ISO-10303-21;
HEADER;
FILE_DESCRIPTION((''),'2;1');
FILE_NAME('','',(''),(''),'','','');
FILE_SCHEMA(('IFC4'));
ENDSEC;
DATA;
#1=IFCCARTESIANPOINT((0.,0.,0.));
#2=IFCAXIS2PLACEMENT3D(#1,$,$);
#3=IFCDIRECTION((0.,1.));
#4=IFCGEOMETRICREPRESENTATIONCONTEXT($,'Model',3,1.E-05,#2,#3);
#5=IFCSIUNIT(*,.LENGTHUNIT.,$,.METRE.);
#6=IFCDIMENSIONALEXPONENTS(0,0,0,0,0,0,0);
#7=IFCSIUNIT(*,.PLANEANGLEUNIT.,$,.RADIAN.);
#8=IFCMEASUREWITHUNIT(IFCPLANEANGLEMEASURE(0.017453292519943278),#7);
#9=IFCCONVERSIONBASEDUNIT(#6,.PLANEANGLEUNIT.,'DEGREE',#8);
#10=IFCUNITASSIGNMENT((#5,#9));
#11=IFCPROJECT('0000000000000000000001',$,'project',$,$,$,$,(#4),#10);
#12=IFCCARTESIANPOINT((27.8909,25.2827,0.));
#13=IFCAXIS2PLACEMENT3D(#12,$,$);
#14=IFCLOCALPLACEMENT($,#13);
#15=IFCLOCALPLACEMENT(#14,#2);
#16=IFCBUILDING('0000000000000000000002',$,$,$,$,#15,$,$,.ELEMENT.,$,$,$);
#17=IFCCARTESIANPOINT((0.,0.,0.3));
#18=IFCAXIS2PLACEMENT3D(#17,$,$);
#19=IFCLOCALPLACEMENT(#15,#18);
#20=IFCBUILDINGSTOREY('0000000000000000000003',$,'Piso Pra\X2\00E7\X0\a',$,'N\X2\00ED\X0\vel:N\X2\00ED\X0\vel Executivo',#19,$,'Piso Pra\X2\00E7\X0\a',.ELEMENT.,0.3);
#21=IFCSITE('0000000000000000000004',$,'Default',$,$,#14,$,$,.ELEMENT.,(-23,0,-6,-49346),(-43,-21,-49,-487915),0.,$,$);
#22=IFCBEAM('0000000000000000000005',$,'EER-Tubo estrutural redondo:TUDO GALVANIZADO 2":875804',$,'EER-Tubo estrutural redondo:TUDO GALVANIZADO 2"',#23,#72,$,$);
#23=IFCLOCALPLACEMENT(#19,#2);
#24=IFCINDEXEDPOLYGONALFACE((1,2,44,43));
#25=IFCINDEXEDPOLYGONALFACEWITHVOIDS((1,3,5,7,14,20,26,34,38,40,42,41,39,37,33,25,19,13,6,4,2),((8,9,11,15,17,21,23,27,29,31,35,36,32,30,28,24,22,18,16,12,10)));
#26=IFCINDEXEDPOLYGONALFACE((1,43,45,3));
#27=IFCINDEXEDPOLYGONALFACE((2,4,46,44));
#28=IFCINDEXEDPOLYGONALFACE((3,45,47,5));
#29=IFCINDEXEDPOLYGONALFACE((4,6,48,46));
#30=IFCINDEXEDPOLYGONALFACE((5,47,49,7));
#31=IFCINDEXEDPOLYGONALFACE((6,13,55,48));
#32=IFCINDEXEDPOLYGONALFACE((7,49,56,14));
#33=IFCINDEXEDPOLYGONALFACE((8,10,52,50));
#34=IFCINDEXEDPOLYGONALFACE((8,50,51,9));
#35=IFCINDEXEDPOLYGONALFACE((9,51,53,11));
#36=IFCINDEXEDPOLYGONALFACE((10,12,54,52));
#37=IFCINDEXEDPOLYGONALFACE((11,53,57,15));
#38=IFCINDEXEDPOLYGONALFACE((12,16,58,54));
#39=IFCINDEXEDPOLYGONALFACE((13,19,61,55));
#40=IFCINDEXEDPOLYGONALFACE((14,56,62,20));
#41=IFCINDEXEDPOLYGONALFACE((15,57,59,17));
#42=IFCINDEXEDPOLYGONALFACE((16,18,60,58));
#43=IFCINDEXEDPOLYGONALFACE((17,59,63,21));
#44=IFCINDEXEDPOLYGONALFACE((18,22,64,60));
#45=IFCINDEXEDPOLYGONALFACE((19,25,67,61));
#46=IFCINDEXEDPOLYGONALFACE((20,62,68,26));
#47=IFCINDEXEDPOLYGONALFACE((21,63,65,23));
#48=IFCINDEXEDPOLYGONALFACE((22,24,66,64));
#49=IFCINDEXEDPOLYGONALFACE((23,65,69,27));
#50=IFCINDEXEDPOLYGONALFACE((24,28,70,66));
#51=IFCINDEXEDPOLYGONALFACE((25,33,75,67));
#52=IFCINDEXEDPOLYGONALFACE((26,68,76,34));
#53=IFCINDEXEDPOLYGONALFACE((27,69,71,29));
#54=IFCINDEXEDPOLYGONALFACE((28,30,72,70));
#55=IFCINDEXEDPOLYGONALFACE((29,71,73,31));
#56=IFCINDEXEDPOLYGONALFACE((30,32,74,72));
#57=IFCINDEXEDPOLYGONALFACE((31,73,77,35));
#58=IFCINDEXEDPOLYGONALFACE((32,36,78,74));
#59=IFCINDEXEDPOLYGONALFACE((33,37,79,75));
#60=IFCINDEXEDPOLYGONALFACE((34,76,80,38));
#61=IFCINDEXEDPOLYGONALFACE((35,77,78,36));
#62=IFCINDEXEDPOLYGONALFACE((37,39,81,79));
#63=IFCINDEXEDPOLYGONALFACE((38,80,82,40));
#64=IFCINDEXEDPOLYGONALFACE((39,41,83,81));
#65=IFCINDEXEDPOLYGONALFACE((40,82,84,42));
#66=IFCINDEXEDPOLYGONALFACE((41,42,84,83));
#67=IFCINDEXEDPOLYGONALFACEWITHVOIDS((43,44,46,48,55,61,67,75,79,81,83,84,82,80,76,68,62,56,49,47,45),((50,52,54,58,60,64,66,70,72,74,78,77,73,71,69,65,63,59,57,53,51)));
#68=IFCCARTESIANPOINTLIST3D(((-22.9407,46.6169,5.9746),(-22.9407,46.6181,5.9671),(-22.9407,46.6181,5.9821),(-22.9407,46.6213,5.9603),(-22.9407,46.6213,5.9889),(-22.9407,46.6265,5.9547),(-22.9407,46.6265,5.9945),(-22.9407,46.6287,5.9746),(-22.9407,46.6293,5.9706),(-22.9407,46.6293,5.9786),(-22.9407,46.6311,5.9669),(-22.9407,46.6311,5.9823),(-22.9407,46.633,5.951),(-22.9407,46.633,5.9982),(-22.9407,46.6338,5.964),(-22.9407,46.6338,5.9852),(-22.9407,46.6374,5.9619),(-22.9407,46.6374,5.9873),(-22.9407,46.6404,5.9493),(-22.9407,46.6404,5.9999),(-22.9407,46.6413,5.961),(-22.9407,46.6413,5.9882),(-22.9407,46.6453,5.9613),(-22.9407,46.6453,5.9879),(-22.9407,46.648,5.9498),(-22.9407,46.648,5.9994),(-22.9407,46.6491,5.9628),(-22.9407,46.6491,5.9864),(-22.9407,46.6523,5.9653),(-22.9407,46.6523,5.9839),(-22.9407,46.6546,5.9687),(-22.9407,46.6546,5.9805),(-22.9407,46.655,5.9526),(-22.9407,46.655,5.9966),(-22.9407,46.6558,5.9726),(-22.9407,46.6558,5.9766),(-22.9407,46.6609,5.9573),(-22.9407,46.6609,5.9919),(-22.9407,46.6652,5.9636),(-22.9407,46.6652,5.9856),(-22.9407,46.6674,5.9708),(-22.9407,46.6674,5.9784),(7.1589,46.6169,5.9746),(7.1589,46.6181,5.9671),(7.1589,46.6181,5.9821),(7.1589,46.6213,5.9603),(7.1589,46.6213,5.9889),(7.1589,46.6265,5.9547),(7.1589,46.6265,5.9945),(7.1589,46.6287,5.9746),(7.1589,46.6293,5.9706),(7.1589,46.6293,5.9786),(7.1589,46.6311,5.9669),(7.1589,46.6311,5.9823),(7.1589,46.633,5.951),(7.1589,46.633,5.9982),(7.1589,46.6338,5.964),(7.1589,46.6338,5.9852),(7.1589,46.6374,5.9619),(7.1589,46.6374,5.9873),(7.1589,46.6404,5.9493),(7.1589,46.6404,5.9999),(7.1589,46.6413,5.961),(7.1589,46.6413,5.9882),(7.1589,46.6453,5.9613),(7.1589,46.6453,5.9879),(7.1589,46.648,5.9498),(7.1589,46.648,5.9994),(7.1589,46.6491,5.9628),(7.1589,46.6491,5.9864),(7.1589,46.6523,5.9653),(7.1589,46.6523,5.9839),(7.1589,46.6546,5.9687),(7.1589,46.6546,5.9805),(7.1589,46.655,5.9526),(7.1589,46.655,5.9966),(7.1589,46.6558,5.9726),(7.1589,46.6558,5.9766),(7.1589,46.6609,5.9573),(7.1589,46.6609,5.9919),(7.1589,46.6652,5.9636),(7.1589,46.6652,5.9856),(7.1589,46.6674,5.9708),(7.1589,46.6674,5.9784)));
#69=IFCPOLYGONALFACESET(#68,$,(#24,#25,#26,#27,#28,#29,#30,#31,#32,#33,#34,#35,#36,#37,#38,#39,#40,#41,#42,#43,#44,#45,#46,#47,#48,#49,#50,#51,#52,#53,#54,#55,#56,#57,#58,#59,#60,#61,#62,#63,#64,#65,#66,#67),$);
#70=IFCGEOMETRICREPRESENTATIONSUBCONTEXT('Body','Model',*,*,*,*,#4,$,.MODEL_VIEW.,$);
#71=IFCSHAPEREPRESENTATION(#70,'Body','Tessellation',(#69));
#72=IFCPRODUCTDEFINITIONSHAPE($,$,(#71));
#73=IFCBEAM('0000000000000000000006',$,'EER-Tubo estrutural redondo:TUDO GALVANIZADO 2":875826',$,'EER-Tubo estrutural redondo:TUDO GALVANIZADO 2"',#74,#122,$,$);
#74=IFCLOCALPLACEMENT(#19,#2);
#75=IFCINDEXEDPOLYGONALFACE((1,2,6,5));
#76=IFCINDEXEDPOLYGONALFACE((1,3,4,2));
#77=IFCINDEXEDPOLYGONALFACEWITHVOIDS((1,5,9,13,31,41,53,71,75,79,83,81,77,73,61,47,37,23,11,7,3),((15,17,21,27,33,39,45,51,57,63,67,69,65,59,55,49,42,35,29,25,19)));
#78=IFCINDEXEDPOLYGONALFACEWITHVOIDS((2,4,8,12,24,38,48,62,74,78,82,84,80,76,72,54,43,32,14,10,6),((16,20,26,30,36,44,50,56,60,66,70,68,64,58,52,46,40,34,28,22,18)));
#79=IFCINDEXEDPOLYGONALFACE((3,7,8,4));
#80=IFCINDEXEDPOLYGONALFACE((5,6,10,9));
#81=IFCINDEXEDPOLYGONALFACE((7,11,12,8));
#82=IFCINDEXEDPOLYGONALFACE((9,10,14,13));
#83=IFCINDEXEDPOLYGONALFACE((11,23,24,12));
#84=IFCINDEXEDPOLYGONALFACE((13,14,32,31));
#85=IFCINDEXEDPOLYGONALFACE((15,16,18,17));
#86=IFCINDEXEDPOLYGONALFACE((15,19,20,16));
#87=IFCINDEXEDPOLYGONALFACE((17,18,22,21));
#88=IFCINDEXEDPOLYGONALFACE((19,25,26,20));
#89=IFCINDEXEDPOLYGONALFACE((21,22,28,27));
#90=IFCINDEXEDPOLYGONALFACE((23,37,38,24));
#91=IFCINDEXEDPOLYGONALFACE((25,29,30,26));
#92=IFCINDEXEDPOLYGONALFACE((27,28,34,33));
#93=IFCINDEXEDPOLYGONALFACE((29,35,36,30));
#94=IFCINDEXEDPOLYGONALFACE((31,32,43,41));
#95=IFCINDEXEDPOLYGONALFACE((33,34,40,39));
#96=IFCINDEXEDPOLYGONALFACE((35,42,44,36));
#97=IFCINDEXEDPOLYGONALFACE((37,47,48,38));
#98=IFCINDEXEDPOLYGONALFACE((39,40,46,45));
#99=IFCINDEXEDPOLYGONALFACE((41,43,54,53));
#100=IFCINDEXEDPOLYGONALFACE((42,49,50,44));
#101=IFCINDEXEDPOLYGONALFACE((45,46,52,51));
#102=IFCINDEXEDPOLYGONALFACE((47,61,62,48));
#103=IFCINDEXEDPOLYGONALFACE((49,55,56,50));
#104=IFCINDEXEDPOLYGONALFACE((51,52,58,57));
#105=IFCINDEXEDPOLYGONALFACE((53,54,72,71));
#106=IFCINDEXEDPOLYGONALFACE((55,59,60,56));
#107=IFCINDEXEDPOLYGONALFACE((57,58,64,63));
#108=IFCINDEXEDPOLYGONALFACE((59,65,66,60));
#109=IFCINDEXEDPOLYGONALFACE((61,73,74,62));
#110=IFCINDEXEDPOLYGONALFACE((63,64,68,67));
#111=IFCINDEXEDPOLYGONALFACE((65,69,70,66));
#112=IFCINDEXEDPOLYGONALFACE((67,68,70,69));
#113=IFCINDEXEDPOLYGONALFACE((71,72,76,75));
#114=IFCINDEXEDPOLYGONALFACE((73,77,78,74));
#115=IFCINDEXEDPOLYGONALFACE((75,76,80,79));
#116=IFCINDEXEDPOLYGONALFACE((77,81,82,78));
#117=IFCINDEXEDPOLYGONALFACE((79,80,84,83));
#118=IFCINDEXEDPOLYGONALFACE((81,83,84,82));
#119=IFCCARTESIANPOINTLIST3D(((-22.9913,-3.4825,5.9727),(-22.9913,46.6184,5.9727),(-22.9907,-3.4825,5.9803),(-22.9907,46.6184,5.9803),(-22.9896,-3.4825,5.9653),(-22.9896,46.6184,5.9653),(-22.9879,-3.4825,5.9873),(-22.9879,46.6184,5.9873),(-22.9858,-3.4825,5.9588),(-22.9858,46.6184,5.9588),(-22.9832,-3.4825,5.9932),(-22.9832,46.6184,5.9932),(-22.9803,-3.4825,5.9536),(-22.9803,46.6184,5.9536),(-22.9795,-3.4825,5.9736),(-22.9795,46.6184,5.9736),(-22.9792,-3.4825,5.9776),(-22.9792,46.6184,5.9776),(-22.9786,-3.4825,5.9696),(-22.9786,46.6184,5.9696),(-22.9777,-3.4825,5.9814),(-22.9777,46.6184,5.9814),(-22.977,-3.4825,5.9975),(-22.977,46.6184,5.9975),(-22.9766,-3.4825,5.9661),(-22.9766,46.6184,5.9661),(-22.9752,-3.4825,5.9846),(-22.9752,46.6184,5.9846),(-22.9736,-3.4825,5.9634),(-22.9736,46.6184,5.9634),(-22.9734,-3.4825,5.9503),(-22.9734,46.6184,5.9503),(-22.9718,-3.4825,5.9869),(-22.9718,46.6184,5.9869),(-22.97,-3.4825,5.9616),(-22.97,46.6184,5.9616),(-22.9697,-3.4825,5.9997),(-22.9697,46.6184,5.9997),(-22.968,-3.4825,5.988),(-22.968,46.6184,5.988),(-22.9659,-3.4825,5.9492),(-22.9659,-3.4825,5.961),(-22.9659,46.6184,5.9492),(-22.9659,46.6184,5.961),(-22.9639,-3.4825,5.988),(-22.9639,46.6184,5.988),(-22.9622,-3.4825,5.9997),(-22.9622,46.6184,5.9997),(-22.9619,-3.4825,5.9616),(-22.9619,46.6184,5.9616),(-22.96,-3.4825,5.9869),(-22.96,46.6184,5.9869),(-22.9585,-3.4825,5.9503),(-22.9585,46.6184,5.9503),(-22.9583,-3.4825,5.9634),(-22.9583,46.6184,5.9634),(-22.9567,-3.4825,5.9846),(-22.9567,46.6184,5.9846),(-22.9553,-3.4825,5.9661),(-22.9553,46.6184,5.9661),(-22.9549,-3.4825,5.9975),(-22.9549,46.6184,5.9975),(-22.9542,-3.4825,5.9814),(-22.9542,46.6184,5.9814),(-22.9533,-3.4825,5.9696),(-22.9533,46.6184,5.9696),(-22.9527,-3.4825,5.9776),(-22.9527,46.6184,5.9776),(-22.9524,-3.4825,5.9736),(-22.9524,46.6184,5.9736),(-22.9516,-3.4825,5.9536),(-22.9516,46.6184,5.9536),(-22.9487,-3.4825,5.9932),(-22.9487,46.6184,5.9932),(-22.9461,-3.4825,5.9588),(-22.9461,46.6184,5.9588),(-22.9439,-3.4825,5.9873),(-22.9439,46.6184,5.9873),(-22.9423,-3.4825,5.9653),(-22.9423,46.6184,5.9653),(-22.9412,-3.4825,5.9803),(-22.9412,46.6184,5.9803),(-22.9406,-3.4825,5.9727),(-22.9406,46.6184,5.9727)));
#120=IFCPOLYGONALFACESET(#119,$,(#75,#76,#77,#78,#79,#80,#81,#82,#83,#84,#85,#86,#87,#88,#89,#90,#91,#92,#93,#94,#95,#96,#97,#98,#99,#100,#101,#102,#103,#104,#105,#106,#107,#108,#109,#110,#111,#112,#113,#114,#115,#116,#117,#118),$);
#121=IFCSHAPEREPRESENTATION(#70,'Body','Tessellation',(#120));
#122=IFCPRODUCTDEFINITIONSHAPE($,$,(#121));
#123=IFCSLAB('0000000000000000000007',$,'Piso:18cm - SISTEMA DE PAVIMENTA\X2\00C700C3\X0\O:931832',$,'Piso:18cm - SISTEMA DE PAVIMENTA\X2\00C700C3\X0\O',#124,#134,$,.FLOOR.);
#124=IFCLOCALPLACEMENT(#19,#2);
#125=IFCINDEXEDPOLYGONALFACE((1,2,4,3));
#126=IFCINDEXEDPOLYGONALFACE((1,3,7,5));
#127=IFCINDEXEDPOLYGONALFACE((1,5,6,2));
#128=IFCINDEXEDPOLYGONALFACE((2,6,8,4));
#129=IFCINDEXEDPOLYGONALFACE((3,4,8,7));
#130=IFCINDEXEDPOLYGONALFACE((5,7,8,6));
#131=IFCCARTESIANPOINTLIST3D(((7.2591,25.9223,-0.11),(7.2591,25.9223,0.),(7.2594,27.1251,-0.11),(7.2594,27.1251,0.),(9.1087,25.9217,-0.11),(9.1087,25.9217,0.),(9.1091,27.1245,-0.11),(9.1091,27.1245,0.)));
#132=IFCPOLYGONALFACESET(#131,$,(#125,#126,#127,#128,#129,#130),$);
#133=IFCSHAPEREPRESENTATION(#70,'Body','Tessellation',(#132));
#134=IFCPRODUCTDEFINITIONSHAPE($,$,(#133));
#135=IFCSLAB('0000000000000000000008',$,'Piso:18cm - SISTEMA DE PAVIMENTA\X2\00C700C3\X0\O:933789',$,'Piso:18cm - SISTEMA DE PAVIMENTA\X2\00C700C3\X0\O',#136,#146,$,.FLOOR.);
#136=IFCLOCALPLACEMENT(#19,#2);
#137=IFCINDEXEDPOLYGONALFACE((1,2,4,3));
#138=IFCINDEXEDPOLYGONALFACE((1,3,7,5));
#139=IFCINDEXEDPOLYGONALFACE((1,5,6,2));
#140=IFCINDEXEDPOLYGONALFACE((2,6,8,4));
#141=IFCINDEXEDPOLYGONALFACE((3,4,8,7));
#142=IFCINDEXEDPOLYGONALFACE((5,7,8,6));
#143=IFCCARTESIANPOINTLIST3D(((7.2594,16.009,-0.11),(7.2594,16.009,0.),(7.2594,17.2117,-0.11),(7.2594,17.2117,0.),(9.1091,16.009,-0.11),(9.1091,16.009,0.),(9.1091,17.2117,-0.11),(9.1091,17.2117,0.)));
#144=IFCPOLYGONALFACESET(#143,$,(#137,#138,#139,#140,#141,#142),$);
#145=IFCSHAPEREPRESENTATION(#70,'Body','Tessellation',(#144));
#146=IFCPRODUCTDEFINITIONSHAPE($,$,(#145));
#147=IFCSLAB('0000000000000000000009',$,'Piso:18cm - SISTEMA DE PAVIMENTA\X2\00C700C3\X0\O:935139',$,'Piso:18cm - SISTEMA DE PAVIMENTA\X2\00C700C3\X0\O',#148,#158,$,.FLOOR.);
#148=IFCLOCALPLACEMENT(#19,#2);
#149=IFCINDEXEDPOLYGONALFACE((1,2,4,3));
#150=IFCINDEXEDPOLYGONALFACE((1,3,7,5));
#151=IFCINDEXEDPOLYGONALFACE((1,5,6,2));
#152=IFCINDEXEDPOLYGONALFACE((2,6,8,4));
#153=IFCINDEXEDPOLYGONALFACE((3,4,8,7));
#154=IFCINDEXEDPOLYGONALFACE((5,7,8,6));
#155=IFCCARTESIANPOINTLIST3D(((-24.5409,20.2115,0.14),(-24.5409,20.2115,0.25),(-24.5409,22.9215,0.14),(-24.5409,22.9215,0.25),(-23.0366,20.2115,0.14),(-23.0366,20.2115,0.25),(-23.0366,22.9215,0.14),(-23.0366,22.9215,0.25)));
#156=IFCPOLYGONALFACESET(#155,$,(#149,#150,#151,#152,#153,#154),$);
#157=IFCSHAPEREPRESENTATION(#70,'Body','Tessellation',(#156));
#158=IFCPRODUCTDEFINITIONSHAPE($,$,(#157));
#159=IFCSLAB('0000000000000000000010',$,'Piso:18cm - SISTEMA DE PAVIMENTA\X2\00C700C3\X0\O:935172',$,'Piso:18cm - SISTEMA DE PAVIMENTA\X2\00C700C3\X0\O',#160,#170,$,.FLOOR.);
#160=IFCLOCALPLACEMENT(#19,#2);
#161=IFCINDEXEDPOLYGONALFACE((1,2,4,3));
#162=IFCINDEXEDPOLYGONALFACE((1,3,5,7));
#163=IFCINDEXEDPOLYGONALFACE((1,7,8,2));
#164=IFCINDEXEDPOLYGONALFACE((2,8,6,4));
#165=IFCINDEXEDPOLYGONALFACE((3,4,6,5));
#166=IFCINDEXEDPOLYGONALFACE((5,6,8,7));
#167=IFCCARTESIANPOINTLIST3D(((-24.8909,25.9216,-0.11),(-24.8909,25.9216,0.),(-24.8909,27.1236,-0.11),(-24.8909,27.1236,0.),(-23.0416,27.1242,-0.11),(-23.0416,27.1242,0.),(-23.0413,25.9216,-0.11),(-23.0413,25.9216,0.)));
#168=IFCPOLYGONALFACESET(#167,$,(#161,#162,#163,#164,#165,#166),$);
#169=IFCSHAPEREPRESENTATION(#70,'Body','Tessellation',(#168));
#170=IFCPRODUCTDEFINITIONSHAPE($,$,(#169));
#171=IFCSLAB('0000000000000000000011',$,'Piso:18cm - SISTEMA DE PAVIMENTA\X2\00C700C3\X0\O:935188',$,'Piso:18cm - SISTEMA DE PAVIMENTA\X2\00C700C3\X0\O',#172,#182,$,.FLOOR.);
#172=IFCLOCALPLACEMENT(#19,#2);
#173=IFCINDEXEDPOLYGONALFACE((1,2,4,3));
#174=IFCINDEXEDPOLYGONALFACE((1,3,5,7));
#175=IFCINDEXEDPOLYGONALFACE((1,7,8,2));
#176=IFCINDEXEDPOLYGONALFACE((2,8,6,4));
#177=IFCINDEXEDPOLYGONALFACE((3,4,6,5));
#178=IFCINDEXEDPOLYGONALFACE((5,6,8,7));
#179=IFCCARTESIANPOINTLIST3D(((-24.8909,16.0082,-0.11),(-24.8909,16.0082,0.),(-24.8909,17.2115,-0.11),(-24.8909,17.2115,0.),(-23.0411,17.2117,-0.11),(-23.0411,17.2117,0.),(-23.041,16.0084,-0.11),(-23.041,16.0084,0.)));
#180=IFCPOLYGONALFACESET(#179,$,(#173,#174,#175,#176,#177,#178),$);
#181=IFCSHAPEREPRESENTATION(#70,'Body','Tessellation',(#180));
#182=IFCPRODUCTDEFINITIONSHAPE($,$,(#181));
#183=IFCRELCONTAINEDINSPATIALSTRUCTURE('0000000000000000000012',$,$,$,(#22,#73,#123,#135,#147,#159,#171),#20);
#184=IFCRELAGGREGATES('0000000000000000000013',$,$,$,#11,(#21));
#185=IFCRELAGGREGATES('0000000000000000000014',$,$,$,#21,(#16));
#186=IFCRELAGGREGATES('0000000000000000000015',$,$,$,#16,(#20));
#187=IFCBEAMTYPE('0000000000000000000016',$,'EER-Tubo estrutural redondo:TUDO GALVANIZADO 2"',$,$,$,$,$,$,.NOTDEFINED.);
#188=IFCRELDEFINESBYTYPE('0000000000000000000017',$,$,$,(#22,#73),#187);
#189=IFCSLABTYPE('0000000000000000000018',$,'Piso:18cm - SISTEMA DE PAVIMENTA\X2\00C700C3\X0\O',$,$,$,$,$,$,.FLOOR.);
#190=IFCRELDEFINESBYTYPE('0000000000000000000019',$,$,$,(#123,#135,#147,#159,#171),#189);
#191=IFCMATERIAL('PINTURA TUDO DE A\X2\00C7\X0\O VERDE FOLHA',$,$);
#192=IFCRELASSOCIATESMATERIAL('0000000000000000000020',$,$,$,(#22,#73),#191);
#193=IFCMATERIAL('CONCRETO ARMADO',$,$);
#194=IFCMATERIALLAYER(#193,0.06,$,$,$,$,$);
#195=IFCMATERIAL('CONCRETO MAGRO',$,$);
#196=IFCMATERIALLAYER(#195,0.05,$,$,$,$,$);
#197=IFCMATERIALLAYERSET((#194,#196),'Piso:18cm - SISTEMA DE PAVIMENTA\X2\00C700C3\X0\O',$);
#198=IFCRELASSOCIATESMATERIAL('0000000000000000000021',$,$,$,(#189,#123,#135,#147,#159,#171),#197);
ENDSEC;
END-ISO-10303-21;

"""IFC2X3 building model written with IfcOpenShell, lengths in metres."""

from ifc_helpers import new_model, entity, si_unit, converted_unit, direction, frame, frame_2d, origin, origin_2d_with_axis, place, context, subcontext, project, spatial, polyline, rectangle, hollow_circle, outline, extrude, material, layer, layer_set, layer_usage, type_object, element, save


model = new_model("IFC2X3")

# Units and contexts
model_context = context("Model", 3, precision=1e-05, world=origin(), true_north=direction((0.0, 1.0)))
body_context = subcontext(model_context, "Body", "Model", "MODEL_VIEW")
ifc_project = project(units=[si_unit("LENGTHUNIT", "METRE"), converted_unit("PLANEANGLEUNIT", "DEGREE", entity("IfcPlaneAngleMeasure", 0.017453292519943278), si_unit("PLANEANGLEUNIT", "RADIAN"), dimensions=[0, 0, 0, 0, 0, 0, 0])], contexts=[model_context])

# Site, building, storey
site_placement = place(None, frame((27.8909, 25.2827, 0.0)))
site = spatial("IfcSite", under=ifc_project, at=site_placement, Name="Default", CompositionType="ELEMENT", RefLatitude=(-23, 0, -6, -49346), RefLongitude=(-43, -21, -49, -487915), RefElevation=0.0)
building_placement = place(site_placement, origin())
building = spatial("IfcBuilding", under=site, at=building_placement, CompositionType="ELEMENT")
storey_placement = place(building_placement, frame((0.0, 0.0, 0.3)))
storey = spatial("IfcBuildingStorey", under=building, at=storey_placement, Name="Piso Praça", ObjectType="Nível:Nível Executivo", LongName="Piso Praça", CompositionType="ELEMENT", Elevation=0.3)

# Shared definitions
ifc_material_1 = material(Name="PINTURA TUDO DE AÇO VERDE FOLHA")

# Beams
beam_type_1 = type_object("IfcBeamType", Name="EER-Tubo estrutural redondo:TUDO GALVANIZADO 2\"", PredefinedType="NOTDEFINED")
beam_1_placement = place(storey_placement, frame((7.1841, 46.6423, 0.0), z_axis=(0.0, 0.0, 1.0), x_axis=(-1.0, 0.0, 0.0)))
element("IfcBeam", 1, at=beam_1_placement, inside=storey, type_object=beam_type_1, material=ifc_material_1, Name="EER-Tubo estrutural redondo:TUDO GALVANIZADO 2\":875804", ObjectType="EER-Tubo estrutural redondo:TUDO GALVANIZADO 2\"", context=body_context, shape_type="SweptSolid", body=[
    extrude(hollow_circle(Radius=0.0254, WallThickness=0.0118, at=origin_2d_with_axis()), frame((0.0252, 0.0, 5.9746), z_axis=(1.0, 0.0, 0.0), x_axis=(0.0, 1.0, 0.0)), (0.0, 0.0, 1.0), 30.0996),
])
beam_2_placement = place(storey_placement, frame((-22.9659, 46.6436, 0.0), z_axis=(0.0, 0.0, 1.0), x_axis=(0.0, -1.0, 0.0)))
element("IfcBeam", 2, at=beam_2_placement, inside=storey, type_object=beam_type_1, material=ifc_material_1, Name="EER-Tubo estrutural redondo:TUDO GALVANIZADO 2\":875826", ObjectType="EER-Tubo estrutural redondo:TUDO GALVANIZADO 2\"", context=body_context, shape_type="SweptSolid", body=[
    extrude(hollow_circle(Radius=0.0254, WallThickness=0.0118, at=origin_2d_with_axis()), frame((0.0252, 0.0, 5.9746), z_axis=(1.0, 0.0, 0.0), x_axis=(0.0, 0.0, -1.0)), (0.0, 0.0, 1.0), 50.1009),
])

# Slabs
ifc_material_2 = material(Name="CONCRETO ARMADO")
ifc_layer_1 = layer(ifc_material_2, 0.06)
ifc_material_3 = material(Name="CONCRETO MAGRO")
ifc_layer_2 = layer(ifc_material_3, 0.05)
ifc_layer_set_1 = layer_set([ifc_layer_1, ifc_layer_2], Name="Piso:18cm - SISTEMA DE PAVIMENTAÇÃO")
ifc_layer_usage_1 = layer_usage(ifc_layer_set_1, "AXIS3", "POSITIVE", 0.0)
slab_type_1 = type_object("IfcSlabType", Name="Piso:18cm - SISTEMA DE PAVIMENTAÇÃO", PredefinedType="FLOOR", material=ifc_layer_set_1)
slab_1_placement = place(storey_placement, origin())
element("IfcSlab", 3, at=slab_1_placement, inside=storey, type_object=slab_type_1, material=ifc_layer_usage_1, Name="Piso:18cm - SISTEMA DE PAVIMENTAÇÃO:931832", ObjectType="Piso:18cm - SISTEMA DE PAVIMENTAÇÃO", PredefinedType="FLOOR", context=body_context, shape_type="SweptSolid", body=[
    extrude(rectangle(XDim=1.8497, YDim=1.2027, at=frame_2d((0.0, 0.0), x_axis=(1.0, 0.0))), frame((8.1841, 26.5234, 0.0), z_axis=(0.0, 0.0, -1.0), x_axis=(1.0, -0.00031, 0.0)), (0.0, 0.0, 1.0), 0.11),
])
slab_2_placement = place(storey_placement, origin())
element("IfcSlab", 4, at=slab_2_placement, inside=storey, type_object=slab_type_1, material=ifc_layer_usage_1, Name="Piso:18cm - SISTEMA DE PAVIMENTAÇÃO:933789", ObjectType="Piso:18cm - SISTEMA DE PAVIMENTAÇÃO", PredefinedType="FLOOR", context=body_context, shape_type="SweptSolid", body=[
    extrude(rectangle(XDim=1.2027, YDim=1.8497, at=frame_2d((0.0, 0.0), x_axis=(1.0, 0.0))), frame((8.1842, 16.6104, 0.0), z_axis=(0.0, 0.0, -1.0), x_axis=(0.0, 1.0, 0.0)), (0.0, 0.0, 1.0), 0.11),
])
slab_3_placement = place(storey_placement, origin())
element("IfcSlab", 5, at=slab_3_placement, inside=storey, type_object=slab_type_1, material=ifc_layer_usage_1, Name="Piso:18cm - SISTEMA DE PAVIMENTAÇÃO:935139", ObjectType="Piso:18cm - SISTEMA DE PAVIMENTAÇÃO", PredefinedType="FLOOR", context=body_context, shape_type="SweptSolid", body=[
    extrude(rectangle(XDim=2.71, YDim=1.5044, at=frame_2d((0.0, 0.0), x_axis=(1.0, 0.0))), frame((-23.7888, 21.5665, 0.25), z_axis=(0.0, 0.0, -1.0), x_axis=(0.0, 1.0, 0.0)), (0.0, 0.0, 1.0), 0.11),
])
slab_4_placement = place(storey_placement, origin())
element("IfcSlab", 6, at=slab_4_placement, inside=storey, type_object=slab_type_1, material=ifc_layer_usage_1, Name="Piso:18cm - SISTEMA DE PAVIMENTAÇÃO:935172", ObjectType="Piso:18cm - SISTEMA DE PAVIMENTAÇÃO", PredefinedType="FLOOR", context=body_context, shape_type="SweptSolid", body=[
    extrude(outline(polyline([(-0.6012, -0.9248), (0.6009, -0.9248), (0.6014, 0.9246), (-0.6012, 0.9249), (-0.6012, -0.9248)])), frame((-23.9662, 26.5228, 0.0), z_axis=(0.0, 0.0, -1.0), x_axis=(0.0, 1.0, 0.0)), (0.0, 0.0, 1.0), 0.11),
])
slab_5_placement = place(storey_placement, origin())
element("IfcSlab", 7, at=slab_5_placement, inside=storey, type_object=slab_type_1, material=ifc_layer_usage_1, Name="Piso:18cm - SISTEMA DE PAVIMENTAÇÃO:935188", ObjectType="Piso:18cm - SISTEMA DE PAVIMENTAÇÃO", PredefinedType="FLOOR", context=body_context, shape_type="SweptSolid", body=[
    extrude(outline(polyline([(-0.6018, -0.9249), (0.6016, -0.9249), (0.6018, 0.9249), (-0.6016, 0.925), (-0.6018, -0.9249)])), frame((-23.966, 16.6099, 0.0), z_axis=(0.0, 0.0, -1.0), x_axis=(0.0, 1.0, 0.0)), (0.0, 0.0, 1.0), 0.11),
])

save(model, "model.ifc")
